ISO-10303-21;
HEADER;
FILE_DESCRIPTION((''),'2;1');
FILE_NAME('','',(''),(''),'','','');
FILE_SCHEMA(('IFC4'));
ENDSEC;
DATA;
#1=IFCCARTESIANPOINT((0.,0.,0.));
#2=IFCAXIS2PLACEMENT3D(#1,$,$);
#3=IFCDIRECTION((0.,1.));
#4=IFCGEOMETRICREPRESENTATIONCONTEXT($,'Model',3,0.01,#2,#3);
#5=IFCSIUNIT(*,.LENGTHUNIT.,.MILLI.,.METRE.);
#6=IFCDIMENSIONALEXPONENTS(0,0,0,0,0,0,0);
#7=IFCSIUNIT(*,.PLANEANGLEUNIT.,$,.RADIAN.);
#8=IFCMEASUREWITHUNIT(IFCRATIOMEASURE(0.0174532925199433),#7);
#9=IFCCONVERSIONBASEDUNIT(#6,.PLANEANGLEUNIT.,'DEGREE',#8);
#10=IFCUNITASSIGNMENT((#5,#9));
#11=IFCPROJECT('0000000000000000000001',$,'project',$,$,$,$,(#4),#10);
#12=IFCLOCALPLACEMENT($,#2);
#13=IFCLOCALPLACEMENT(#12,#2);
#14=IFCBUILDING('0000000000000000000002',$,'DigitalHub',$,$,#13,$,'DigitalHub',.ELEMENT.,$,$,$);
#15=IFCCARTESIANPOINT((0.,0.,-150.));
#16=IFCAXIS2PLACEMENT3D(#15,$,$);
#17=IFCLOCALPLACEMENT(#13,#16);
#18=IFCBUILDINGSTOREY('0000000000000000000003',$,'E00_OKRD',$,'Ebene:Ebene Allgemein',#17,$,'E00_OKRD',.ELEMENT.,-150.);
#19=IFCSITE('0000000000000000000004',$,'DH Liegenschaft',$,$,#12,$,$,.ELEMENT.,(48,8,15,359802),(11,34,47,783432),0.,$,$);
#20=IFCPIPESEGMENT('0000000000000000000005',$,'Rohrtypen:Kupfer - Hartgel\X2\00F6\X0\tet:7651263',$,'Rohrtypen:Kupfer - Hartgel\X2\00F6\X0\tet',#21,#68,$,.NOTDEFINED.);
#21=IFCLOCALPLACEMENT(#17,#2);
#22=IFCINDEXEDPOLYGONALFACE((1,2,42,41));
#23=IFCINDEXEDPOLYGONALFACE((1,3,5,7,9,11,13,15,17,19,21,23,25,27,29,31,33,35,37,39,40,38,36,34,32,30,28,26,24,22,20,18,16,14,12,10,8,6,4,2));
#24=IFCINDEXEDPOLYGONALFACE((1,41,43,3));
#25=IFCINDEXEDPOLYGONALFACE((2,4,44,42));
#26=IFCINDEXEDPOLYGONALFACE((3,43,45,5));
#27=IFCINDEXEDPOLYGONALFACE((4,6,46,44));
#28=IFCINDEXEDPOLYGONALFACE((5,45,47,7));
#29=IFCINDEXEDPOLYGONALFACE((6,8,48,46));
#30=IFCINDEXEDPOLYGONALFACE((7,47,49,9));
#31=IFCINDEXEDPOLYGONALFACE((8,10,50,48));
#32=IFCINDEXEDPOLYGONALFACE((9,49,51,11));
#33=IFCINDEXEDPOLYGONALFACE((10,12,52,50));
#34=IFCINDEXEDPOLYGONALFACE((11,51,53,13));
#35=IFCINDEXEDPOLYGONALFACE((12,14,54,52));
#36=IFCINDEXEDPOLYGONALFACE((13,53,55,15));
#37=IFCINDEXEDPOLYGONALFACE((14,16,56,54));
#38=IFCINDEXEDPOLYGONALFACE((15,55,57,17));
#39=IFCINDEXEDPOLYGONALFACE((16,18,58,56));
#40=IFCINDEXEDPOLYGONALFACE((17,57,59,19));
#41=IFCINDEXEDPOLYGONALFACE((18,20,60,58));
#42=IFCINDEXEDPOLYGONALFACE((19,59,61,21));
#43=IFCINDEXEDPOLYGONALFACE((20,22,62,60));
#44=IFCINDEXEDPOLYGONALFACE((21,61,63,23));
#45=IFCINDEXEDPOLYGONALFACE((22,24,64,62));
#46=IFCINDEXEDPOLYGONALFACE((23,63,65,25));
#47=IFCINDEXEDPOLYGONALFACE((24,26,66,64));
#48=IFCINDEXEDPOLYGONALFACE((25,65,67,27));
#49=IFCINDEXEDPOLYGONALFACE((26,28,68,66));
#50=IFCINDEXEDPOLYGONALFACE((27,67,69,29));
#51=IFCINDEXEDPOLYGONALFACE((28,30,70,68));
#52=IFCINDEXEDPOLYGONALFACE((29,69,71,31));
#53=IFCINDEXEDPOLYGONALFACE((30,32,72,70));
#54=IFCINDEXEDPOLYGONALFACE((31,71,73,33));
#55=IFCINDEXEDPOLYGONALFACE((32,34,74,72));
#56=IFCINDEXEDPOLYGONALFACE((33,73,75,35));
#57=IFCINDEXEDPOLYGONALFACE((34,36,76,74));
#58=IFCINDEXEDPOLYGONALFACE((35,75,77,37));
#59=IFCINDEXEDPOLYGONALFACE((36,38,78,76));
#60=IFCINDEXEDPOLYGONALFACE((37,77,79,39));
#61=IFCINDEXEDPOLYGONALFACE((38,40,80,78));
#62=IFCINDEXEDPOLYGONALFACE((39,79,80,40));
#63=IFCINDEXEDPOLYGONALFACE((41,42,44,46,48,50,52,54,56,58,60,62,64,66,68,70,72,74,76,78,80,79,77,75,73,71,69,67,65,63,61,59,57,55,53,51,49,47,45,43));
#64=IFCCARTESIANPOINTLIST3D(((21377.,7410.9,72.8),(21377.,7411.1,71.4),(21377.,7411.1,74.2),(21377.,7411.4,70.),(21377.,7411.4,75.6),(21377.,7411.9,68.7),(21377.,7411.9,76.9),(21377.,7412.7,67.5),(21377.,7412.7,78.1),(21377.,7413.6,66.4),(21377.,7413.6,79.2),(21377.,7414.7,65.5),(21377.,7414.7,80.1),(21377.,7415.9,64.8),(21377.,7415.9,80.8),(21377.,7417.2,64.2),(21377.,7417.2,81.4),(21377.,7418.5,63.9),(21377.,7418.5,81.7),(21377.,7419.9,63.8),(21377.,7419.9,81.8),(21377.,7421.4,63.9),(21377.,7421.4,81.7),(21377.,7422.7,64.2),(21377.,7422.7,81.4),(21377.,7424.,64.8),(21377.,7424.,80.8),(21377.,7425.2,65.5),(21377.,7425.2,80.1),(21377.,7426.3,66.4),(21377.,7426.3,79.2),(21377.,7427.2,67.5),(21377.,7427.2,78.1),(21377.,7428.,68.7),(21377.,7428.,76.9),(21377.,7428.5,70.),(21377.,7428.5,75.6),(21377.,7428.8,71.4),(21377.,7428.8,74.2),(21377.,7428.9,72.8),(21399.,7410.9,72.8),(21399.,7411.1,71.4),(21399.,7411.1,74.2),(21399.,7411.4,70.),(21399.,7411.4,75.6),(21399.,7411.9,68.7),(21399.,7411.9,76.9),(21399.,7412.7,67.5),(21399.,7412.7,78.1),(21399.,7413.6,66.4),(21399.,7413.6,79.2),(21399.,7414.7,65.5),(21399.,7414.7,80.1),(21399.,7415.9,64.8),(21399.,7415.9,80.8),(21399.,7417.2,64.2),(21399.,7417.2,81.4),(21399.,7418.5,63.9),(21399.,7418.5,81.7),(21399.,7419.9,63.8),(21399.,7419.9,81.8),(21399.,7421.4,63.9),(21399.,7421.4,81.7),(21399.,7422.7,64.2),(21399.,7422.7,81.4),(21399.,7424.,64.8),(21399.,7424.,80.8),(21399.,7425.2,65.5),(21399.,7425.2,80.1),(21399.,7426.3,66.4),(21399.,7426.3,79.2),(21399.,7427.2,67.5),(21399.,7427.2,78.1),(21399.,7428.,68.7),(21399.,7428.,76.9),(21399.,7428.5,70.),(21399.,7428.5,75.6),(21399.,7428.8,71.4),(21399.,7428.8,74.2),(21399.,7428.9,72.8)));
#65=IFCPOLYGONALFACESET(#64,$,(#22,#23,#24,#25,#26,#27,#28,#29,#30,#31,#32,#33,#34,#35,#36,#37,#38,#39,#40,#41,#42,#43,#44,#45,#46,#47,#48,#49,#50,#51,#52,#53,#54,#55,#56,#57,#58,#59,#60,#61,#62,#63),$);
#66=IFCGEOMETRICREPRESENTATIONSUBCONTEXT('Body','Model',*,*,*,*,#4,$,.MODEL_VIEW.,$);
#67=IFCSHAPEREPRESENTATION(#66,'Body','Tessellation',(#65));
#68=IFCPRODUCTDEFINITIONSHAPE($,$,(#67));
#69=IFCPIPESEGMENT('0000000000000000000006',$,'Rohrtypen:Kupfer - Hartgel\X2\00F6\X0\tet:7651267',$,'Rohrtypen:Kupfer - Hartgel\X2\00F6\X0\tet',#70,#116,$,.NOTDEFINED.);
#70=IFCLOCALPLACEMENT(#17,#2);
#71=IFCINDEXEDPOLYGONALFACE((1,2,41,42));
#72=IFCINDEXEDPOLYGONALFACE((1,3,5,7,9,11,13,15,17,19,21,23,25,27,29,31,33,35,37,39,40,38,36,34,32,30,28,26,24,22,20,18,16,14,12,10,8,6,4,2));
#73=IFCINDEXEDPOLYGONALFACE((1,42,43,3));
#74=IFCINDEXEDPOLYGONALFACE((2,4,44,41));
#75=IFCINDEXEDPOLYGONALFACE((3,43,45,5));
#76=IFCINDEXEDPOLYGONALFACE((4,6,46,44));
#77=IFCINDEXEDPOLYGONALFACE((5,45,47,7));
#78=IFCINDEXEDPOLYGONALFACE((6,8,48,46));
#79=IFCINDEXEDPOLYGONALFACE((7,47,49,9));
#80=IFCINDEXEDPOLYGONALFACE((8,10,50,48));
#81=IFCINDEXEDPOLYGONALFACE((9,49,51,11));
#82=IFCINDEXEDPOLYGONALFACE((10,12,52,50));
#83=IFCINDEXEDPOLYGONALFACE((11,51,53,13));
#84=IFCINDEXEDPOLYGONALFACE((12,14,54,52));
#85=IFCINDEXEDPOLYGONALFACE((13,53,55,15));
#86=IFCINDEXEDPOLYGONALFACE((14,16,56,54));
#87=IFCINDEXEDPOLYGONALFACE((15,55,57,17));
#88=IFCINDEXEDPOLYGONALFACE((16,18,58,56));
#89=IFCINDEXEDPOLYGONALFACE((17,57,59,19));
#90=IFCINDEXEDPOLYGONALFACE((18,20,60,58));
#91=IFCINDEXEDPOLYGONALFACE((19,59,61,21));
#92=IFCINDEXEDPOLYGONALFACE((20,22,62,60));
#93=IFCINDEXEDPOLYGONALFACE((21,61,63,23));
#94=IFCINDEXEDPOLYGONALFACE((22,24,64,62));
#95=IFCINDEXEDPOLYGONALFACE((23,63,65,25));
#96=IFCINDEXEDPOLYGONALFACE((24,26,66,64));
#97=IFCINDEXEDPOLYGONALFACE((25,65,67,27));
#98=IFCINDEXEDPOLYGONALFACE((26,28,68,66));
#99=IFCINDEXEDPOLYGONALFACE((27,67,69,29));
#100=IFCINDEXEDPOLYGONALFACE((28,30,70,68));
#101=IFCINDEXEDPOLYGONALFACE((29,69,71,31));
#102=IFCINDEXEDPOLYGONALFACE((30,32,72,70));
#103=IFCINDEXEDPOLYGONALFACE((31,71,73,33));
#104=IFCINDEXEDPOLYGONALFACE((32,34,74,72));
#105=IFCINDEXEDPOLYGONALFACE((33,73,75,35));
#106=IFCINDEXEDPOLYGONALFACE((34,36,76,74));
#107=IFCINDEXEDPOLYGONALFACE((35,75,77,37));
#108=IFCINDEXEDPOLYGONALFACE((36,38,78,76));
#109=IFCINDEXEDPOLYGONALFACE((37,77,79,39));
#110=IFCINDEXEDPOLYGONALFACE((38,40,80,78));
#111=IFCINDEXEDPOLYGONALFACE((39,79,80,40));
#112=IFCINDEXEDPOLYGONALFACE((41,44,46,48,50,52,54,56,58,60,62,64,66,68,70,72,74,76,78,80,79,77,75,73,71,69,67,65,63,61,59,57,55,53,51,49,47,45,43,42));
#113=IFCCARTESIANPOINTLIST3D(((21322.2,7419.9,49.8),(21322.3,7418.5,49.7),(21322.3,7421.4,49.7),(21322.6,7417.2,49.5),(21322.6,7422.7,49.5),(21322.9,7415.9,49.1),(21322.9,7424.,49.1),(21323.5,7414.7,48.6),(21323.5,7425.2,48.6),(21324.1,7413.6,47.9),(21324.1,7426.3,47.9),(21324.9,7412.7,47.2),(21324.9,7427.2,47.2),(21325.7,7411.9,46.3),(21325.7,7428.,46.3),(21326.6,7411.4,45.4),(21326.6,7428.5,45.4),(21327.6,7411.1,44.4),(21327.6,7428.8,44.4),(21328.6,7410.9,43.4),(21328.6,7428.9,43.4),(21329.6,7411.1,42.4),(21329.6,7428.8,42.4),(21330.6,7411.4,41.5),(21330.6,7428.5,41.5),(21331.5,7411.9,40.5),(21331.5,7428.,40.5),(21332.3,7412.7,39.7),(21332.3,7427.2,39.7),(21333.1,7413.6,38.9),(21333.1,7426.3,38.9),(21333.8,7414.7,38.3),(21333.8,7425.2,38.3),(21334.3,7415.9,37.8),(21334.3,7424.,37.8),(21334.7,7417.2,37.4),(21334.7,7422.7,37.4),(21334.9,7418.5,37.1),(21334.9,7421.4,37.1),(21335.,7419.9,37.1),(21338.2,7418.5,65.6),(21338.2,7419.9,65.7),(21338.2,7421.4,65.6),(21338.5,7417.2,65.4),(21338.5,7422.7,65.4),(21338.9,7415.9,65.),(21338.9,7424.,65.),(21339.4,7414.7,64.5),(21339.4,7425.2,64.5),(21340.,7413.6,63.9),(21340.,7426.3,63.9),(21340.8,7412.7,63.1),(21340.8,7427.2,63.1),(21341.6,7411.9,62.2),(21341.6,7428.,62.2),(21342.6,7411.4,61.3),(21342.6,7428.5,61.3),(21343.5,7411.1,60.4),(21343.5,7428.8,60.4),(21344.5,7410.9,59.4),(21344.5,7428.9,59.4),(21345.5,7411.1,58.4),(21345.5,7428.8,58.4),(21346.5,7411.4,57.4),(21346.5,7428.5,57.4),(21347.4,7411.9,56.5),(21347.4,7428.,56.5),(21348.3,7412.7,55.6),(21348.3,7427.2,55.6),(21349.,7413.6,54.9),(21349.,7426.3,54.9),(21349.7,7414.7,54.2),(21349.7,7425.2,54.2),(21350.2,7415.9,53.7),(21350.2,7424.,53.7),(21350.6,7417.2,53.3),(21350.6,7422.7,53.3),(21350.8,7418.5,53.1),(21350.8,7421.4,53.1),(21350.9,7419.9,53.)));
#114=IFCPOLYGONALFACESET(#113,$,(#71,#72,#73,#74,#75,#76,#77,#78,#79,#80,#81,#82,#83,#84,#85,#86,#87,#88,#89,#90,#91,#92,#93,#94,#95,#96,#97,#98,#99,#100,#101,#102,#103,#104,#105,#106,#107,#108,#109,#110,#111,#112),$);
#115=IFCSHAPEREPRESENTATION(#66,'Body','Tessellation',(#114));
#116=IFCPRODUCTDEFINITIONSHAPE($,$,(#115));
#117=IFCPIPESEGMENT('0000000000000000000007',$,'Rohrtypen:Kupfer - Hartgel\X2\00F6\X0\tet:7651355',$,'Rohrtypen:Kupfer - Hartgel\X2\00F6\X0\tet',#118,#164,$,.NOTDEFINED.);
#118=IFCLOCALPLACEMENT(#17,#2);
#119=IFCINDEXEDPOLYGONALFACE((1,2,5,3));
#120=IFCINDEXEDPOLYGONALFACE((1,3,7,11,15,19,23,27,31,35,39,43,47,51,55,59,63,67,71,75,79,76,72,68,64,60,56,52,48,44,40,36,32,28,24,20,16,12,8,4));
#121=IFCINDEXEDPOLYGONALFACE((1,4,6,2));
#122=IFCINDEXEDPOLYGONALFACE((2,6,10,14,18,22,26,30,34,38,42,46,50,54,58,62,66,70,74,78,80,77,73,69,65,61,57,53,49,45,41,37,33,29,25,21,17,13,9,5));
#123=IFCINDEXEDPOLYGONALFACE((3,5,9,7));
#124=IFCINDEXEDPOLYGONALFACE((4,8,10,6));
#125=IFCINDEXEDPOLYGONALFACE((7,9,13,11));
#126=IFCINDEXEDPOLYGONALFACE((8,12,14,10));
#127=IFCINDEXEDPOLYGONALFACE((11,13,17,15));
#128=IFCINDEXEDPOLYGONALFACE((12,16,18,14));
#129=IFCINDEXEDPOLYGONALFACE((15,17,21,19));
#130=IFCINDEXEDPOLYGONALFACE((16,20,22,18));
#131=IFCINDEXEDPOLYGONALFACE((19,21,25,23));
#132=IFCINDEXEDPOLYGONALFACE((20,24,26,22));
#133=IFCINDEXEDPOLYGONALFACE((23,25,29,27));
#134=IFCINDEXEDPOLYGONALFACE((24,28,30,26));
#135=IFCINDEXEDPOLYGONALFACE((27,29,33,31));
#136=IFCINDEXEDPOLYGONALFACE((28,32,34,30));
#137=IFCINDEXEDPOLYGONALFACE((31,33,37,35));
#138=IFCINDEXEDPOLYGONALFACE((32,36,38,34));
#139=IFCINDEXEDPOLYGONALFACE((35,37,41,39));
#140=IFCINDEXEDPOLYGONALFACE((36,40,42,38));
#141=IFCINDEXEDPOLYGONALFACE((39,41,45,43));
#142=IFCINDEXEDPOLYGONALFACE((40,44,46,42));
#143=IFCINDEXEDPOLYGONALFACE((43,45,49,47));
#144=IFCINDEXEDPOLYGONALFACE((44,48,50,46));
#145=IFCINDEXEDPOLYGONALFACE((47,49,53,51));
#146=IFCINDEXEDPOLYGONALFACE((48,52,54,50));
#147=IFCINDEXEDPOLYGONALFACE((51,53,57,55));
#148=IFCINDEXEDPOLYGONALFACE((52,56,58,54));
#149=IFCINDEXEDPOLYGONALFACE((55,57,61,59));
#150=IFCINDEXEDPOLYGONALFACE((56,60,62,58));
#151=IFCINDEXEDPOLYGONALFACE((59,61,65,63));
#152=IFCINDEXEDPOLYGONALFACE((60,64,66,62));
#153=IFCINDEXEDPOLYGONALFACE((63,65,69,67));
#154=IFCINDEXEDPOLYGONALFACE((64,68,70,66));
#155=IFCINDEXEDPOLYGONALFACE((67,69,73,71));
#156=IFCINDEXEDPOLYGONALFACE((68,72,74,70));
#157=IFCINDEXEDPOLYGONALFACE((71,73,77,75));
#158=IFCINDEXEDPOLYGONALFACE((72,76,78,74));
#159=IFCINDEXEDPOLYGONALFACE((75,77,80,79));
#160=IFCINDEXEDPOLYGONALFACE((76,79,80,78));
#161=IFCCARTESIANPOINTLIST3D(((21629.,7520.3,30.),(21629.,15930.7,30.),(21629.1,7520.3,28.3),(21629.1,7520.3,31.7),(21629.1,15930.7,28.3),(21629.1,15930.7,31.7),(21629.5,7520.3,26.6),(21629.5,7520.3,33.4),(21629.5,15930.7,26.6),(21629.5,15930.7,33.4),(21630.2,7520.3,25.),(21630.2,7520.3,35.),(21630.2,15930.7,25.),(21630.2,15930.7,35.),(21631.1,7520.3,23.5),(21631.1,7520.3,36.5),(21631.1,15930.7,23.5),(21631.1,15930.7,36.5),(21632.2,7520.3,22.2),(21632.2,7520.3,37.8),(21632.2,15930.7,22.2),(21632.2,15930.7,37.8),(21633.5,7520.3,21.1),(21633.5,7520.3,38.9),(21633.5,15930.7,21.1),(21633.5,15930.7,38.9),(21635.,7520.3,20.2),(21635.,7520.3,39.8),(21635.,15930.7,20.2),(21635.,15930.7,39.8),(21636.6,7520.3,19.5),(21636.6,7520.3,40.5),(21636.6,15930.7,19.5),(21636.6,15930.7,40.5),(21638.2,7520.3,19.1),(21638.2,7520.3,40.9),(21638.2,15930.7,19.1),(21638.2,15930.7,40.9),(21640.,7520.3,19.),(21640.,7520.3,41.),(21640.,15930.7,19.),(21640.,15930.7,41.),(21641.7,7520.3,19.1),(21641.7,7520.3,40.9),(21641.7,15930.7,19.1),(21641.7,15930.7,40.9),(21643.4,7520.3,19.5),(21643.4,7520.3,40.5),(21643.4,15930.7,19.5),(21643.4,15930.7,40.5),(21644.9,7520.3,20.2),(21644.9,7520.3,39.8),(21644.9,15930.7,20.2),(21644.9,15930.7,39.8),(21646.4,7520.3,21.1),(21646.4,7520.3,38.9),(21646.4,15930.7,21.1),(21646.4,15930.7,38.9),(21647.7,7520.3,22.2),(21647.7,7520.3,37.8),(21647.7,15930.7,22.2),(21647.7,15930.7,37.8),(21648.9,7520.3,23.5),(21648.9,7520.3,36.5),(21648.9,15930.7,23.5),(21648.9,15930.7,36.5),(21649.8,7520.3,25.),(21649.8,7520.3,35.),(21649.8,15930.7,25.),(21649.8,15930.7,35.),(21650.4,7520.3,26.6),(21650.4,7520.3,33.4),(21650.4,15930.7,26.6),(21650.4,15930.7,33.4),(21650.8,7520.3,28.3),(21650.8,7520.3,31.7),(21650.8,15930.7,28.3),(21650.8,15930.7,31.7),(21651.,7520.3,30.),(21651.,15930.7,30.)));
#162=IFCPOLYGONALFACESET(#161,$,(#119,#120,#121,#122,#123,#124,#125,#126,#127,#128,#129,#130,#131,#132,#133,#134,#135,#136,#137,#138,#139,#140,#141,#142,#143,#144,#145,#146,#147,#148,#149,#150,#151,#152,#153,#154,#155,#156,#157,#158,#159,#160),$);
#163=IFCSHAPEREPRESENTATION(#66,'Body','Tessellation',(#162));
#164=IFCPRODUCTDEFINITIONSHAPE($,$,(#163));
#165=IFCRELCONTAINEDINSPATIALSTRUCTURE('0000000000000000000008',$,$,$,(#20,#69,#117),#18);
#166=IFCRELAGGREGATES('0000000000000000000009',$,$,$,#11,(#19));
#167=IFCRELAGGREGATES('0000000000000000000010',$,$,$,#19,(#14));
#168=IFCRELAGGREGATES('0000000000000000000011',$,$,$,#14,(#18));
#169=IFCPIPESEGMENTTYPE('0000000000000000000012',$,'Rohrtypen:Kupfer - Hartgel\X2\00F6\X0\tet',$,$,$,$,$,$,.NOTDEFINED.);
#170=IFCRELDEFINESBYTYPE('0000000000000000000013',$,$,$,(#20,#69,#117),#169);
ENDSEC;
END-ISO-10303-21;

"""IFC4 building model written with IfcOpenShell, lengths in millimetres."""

from ifc_helpers import new_model, entity, si_unit, converted_unit, direction, frame, origin, place, context, subcontext, project, spatial, indexed_curve, outline, extrude, type_object, element, save


model = new_model("IFC4")

# Units and contexts
model_context = context("Model", 3, precision=0.01, world=origin(), true_north=direction((0.0, 1.0)))
body_context = subcontext(model_context, "Body", "Model", "MODEL_VIEW")
ifc_project = project(units=[si_unit("LENGTHUNIT", "METRE", prefix="MILLI"), converted_unit("PLANEANGLEUNIT", "DEGREE", entity("IfcRatioMeasure", 0.0174532925199433), si_unit("PLANEANGLEUNIT", "RADIAN"), dimensions=[0, 0, 0, 0, 0, 0, 0])], contexts=[model_context])

# Site, building, storey
site_placement = place(None, origin())
site = spatial("IfcSite", under=ifc_project, at=site_placement, Name="DH Liegenschaft", CompositionType="ELEMENT", RefLatitude=(48, 8, 15, 359802), RefLongitude=(11, 34, 47, 783432), RefElevation=0.0)
building_placement = place(site_placement, origin())
building = spatial("IfcBuilding", under=site, at=building_placement, Name="DigitalHub", LongName="DigitalHub", CompositionType="ELEMENT")
storey_placement = place(building_placement, frame((0.0, 0.0, -150.0)))
storey = spatial("IfcBuildingStorey", under=building, at=storey_placement, Name="E00_OKRD", ObjectType="Ebene:Ebene Allgemein", LongName="E00_OKRD", CompositionType="ELEMENT", Elevation=-150.0)

# Pipe segments
pipe_segment_type = type_object("IfcPipeSegmentType", Name="Rohrtypen:Kupfer - Hartgelötet", PredefinedType="NOTDEFINED")
pipe_segment_1_placement = place(storey_placement, frame((21377.0, 7409.3, 62.2)))
element("IfcPipeSegment", 1, at=pipe_segment_1_placement, inside=storey, type_object=pipe_segment_type, Name="Rohrtypen:Kupfer - Hartgelötet:7651263", ObjectType="Rohrtypen:Kupfer - Hartgelötet", PredefinedType="NOTDEFINED", context=body_context, shape_type="SweptSolid", body=[
    extrude(outline(indexed_curve([(9.0, 0.0), (8.9, 1.4), (8.6, 2.8), (8.0, 4.1), (7.3, 5.3), (6.4, 6.4), (5.3, 7.3), (4.1, 8.0), (2.8, 8.6), (1.4, 8.9), (0.0, 9.0), (-1.4, 8.9), (-2.8, 8.6), (-4.1, 8.0), (-5.3, 7.3), (-6.4, 6.4), (-7.3, 5.3), (-8.0, 4.1), (-8.6, 2.8), (-8.9, 1.4), (-9.0, 0.0), (-8.9, -1.4), (-8.6, -2.8), (-8.0, -4.1), (-7.3, -5.3), (-6.4, -6.4), (-5.3, -7.3), (-4.1, -8.0), (-2.8, -8.6), (-1.4, -8.9), (0.0, -9.0), (1.4, -8.9), (2.8, -8.6), (4.1, -8.0), (5.3, -7.3), (6.4, -6.4), (7.3, -5.3), (8.0, -4.1), (8.6, -2.8), (8.9, -1.4), (9.0, 0.0)], self_intersect=False)), frame((0.0, 10.6, 10.6), z_axis=(1.0, 0.0, 0.0), x_axis=(0.0, 1.0, 0.0)), (0.0, 0.0, 1.0), 22.0),
])
pipe_segment_2_placement = place(storey_placement, frame((21320.6, 7409.3, 35.5)))
element("IfcPipeSegment", 2, at=pipe_segment_2_placement, inside=storey, type_object=pipe_segment_type, Name="Rohrtypen:Kupfer - Hartgelötet:7651267", ObjectType="Rohrtypen:Kupfer - Hartgelötet", PredefinedType="NOTDEFINED", context=body_context, shape_type="SweptSolid", body=[
    extrude(outline(indexed_curve([(9.0, 0.0), (8.9, 1.4), (8.6, 2.8), (8.0, 4.1), (7.3, 5.3), (6.4, 6.4), (5.3, 7.3), (4.1, 8.0), (2.8, 8.6), (1.4, 8.9), (0.0, 9.0), (-1.4, 8.9), (-2.8, 8.6), (-4.1, 8.0), (-5.3, 7.3), (-6.4, 6.4), (-7.3, 5.3), (-8.0, 4.1), (-8.6, 2.8), (-8.9, 1.4), (-9.0, 0.0), (-8.9, -1.4), (-8.6, -2.8), (-8.0, -4.1), (-7.3, -5.3), (-6.4, -6.4), (-5.3, -7.3), (-4.1, -8.0), (-2.8, -8.6), (-1.4, -8.9), (0.0, -9.0), (1.4, -8.9), (2.8, -8.6), (4.1, -8.0), (5.3, -7.3), (6.4, -6.4), (7.3, -5.3), (8.0, -4.1), (8.6, -2.8), (8.9, -1.4), (9.0, 0.0)], self_intersect=False)), frame((8.0, 10.6, 8.0), z_axis=(0.707107, 0.0, 0.707107), x_axis=(0.0, 1.0, 0.0)), (0.0, 0.0, 1.0), 22.5),
])
pipe_segment_3_placement = place(storey_placement, frame((21627.4, 7520.3, 17.4)))
element("IfcPipeSegment", 3, at=pipe_segment_3_placement, inside=storey, type_object=pipe_segment_type, Name="Rohrtypen:Kupfer - Hartgelötet:7651355", ObjectType="Rohrtypen:Kupfer - Hartgelötet", PredefinedType="NOTDEFINED", context=body_context, shape_type="SweptSolid", body=[
    extrude(outline(indexed_curve([(11.0, 0.0), (10.9, 1.7), (10.5, 3.4), (9.8, 5.0), (8.9, 6.5), (7.8, 7.8), (6.5, 8.9), (5.0, 9.8), (3.4, 10.5), (1.7, 10.9), (0.0, 11.0), (-1.7, 10.9), (-3.4, 10.5), (-5.0, 9.8), (-6.5, 8.9), (-7.8, 7.8), (-8.9, 6.5), (-9.8, 5.0), (-10.5, 3.4), (-10.9, 1.7), (-11.0, 0.0), (-10.9, -1.7), (-10.5, -3.4), (-9.8, -5.0), (-8.9, -6.5), (-7.8, -7.8), (-6.5, -8.9), (-5.0, -9.8), (-3.4, -10.5), (-1.7, -10.9), (0.0, -11.0), (1.7, -10.9), (3.4, -10.5), (5.0, -9.8), (6.5, -8.9), (7.8, -7.8), (8.9, -6.5), (9.8, -5.0), (10.5, -3.4), (10.9, -1.7), (11.0, 0.0)], self_intersect=False)), frame((12.6, 0.0, 12.6), z_axis=(0.0, 1.0, 0.0), x_axis=(-1.0, 0.0, 0.0)), (0.0, 0.0, 1.0), 8410.4),
])

save(model, "model.ifc")
